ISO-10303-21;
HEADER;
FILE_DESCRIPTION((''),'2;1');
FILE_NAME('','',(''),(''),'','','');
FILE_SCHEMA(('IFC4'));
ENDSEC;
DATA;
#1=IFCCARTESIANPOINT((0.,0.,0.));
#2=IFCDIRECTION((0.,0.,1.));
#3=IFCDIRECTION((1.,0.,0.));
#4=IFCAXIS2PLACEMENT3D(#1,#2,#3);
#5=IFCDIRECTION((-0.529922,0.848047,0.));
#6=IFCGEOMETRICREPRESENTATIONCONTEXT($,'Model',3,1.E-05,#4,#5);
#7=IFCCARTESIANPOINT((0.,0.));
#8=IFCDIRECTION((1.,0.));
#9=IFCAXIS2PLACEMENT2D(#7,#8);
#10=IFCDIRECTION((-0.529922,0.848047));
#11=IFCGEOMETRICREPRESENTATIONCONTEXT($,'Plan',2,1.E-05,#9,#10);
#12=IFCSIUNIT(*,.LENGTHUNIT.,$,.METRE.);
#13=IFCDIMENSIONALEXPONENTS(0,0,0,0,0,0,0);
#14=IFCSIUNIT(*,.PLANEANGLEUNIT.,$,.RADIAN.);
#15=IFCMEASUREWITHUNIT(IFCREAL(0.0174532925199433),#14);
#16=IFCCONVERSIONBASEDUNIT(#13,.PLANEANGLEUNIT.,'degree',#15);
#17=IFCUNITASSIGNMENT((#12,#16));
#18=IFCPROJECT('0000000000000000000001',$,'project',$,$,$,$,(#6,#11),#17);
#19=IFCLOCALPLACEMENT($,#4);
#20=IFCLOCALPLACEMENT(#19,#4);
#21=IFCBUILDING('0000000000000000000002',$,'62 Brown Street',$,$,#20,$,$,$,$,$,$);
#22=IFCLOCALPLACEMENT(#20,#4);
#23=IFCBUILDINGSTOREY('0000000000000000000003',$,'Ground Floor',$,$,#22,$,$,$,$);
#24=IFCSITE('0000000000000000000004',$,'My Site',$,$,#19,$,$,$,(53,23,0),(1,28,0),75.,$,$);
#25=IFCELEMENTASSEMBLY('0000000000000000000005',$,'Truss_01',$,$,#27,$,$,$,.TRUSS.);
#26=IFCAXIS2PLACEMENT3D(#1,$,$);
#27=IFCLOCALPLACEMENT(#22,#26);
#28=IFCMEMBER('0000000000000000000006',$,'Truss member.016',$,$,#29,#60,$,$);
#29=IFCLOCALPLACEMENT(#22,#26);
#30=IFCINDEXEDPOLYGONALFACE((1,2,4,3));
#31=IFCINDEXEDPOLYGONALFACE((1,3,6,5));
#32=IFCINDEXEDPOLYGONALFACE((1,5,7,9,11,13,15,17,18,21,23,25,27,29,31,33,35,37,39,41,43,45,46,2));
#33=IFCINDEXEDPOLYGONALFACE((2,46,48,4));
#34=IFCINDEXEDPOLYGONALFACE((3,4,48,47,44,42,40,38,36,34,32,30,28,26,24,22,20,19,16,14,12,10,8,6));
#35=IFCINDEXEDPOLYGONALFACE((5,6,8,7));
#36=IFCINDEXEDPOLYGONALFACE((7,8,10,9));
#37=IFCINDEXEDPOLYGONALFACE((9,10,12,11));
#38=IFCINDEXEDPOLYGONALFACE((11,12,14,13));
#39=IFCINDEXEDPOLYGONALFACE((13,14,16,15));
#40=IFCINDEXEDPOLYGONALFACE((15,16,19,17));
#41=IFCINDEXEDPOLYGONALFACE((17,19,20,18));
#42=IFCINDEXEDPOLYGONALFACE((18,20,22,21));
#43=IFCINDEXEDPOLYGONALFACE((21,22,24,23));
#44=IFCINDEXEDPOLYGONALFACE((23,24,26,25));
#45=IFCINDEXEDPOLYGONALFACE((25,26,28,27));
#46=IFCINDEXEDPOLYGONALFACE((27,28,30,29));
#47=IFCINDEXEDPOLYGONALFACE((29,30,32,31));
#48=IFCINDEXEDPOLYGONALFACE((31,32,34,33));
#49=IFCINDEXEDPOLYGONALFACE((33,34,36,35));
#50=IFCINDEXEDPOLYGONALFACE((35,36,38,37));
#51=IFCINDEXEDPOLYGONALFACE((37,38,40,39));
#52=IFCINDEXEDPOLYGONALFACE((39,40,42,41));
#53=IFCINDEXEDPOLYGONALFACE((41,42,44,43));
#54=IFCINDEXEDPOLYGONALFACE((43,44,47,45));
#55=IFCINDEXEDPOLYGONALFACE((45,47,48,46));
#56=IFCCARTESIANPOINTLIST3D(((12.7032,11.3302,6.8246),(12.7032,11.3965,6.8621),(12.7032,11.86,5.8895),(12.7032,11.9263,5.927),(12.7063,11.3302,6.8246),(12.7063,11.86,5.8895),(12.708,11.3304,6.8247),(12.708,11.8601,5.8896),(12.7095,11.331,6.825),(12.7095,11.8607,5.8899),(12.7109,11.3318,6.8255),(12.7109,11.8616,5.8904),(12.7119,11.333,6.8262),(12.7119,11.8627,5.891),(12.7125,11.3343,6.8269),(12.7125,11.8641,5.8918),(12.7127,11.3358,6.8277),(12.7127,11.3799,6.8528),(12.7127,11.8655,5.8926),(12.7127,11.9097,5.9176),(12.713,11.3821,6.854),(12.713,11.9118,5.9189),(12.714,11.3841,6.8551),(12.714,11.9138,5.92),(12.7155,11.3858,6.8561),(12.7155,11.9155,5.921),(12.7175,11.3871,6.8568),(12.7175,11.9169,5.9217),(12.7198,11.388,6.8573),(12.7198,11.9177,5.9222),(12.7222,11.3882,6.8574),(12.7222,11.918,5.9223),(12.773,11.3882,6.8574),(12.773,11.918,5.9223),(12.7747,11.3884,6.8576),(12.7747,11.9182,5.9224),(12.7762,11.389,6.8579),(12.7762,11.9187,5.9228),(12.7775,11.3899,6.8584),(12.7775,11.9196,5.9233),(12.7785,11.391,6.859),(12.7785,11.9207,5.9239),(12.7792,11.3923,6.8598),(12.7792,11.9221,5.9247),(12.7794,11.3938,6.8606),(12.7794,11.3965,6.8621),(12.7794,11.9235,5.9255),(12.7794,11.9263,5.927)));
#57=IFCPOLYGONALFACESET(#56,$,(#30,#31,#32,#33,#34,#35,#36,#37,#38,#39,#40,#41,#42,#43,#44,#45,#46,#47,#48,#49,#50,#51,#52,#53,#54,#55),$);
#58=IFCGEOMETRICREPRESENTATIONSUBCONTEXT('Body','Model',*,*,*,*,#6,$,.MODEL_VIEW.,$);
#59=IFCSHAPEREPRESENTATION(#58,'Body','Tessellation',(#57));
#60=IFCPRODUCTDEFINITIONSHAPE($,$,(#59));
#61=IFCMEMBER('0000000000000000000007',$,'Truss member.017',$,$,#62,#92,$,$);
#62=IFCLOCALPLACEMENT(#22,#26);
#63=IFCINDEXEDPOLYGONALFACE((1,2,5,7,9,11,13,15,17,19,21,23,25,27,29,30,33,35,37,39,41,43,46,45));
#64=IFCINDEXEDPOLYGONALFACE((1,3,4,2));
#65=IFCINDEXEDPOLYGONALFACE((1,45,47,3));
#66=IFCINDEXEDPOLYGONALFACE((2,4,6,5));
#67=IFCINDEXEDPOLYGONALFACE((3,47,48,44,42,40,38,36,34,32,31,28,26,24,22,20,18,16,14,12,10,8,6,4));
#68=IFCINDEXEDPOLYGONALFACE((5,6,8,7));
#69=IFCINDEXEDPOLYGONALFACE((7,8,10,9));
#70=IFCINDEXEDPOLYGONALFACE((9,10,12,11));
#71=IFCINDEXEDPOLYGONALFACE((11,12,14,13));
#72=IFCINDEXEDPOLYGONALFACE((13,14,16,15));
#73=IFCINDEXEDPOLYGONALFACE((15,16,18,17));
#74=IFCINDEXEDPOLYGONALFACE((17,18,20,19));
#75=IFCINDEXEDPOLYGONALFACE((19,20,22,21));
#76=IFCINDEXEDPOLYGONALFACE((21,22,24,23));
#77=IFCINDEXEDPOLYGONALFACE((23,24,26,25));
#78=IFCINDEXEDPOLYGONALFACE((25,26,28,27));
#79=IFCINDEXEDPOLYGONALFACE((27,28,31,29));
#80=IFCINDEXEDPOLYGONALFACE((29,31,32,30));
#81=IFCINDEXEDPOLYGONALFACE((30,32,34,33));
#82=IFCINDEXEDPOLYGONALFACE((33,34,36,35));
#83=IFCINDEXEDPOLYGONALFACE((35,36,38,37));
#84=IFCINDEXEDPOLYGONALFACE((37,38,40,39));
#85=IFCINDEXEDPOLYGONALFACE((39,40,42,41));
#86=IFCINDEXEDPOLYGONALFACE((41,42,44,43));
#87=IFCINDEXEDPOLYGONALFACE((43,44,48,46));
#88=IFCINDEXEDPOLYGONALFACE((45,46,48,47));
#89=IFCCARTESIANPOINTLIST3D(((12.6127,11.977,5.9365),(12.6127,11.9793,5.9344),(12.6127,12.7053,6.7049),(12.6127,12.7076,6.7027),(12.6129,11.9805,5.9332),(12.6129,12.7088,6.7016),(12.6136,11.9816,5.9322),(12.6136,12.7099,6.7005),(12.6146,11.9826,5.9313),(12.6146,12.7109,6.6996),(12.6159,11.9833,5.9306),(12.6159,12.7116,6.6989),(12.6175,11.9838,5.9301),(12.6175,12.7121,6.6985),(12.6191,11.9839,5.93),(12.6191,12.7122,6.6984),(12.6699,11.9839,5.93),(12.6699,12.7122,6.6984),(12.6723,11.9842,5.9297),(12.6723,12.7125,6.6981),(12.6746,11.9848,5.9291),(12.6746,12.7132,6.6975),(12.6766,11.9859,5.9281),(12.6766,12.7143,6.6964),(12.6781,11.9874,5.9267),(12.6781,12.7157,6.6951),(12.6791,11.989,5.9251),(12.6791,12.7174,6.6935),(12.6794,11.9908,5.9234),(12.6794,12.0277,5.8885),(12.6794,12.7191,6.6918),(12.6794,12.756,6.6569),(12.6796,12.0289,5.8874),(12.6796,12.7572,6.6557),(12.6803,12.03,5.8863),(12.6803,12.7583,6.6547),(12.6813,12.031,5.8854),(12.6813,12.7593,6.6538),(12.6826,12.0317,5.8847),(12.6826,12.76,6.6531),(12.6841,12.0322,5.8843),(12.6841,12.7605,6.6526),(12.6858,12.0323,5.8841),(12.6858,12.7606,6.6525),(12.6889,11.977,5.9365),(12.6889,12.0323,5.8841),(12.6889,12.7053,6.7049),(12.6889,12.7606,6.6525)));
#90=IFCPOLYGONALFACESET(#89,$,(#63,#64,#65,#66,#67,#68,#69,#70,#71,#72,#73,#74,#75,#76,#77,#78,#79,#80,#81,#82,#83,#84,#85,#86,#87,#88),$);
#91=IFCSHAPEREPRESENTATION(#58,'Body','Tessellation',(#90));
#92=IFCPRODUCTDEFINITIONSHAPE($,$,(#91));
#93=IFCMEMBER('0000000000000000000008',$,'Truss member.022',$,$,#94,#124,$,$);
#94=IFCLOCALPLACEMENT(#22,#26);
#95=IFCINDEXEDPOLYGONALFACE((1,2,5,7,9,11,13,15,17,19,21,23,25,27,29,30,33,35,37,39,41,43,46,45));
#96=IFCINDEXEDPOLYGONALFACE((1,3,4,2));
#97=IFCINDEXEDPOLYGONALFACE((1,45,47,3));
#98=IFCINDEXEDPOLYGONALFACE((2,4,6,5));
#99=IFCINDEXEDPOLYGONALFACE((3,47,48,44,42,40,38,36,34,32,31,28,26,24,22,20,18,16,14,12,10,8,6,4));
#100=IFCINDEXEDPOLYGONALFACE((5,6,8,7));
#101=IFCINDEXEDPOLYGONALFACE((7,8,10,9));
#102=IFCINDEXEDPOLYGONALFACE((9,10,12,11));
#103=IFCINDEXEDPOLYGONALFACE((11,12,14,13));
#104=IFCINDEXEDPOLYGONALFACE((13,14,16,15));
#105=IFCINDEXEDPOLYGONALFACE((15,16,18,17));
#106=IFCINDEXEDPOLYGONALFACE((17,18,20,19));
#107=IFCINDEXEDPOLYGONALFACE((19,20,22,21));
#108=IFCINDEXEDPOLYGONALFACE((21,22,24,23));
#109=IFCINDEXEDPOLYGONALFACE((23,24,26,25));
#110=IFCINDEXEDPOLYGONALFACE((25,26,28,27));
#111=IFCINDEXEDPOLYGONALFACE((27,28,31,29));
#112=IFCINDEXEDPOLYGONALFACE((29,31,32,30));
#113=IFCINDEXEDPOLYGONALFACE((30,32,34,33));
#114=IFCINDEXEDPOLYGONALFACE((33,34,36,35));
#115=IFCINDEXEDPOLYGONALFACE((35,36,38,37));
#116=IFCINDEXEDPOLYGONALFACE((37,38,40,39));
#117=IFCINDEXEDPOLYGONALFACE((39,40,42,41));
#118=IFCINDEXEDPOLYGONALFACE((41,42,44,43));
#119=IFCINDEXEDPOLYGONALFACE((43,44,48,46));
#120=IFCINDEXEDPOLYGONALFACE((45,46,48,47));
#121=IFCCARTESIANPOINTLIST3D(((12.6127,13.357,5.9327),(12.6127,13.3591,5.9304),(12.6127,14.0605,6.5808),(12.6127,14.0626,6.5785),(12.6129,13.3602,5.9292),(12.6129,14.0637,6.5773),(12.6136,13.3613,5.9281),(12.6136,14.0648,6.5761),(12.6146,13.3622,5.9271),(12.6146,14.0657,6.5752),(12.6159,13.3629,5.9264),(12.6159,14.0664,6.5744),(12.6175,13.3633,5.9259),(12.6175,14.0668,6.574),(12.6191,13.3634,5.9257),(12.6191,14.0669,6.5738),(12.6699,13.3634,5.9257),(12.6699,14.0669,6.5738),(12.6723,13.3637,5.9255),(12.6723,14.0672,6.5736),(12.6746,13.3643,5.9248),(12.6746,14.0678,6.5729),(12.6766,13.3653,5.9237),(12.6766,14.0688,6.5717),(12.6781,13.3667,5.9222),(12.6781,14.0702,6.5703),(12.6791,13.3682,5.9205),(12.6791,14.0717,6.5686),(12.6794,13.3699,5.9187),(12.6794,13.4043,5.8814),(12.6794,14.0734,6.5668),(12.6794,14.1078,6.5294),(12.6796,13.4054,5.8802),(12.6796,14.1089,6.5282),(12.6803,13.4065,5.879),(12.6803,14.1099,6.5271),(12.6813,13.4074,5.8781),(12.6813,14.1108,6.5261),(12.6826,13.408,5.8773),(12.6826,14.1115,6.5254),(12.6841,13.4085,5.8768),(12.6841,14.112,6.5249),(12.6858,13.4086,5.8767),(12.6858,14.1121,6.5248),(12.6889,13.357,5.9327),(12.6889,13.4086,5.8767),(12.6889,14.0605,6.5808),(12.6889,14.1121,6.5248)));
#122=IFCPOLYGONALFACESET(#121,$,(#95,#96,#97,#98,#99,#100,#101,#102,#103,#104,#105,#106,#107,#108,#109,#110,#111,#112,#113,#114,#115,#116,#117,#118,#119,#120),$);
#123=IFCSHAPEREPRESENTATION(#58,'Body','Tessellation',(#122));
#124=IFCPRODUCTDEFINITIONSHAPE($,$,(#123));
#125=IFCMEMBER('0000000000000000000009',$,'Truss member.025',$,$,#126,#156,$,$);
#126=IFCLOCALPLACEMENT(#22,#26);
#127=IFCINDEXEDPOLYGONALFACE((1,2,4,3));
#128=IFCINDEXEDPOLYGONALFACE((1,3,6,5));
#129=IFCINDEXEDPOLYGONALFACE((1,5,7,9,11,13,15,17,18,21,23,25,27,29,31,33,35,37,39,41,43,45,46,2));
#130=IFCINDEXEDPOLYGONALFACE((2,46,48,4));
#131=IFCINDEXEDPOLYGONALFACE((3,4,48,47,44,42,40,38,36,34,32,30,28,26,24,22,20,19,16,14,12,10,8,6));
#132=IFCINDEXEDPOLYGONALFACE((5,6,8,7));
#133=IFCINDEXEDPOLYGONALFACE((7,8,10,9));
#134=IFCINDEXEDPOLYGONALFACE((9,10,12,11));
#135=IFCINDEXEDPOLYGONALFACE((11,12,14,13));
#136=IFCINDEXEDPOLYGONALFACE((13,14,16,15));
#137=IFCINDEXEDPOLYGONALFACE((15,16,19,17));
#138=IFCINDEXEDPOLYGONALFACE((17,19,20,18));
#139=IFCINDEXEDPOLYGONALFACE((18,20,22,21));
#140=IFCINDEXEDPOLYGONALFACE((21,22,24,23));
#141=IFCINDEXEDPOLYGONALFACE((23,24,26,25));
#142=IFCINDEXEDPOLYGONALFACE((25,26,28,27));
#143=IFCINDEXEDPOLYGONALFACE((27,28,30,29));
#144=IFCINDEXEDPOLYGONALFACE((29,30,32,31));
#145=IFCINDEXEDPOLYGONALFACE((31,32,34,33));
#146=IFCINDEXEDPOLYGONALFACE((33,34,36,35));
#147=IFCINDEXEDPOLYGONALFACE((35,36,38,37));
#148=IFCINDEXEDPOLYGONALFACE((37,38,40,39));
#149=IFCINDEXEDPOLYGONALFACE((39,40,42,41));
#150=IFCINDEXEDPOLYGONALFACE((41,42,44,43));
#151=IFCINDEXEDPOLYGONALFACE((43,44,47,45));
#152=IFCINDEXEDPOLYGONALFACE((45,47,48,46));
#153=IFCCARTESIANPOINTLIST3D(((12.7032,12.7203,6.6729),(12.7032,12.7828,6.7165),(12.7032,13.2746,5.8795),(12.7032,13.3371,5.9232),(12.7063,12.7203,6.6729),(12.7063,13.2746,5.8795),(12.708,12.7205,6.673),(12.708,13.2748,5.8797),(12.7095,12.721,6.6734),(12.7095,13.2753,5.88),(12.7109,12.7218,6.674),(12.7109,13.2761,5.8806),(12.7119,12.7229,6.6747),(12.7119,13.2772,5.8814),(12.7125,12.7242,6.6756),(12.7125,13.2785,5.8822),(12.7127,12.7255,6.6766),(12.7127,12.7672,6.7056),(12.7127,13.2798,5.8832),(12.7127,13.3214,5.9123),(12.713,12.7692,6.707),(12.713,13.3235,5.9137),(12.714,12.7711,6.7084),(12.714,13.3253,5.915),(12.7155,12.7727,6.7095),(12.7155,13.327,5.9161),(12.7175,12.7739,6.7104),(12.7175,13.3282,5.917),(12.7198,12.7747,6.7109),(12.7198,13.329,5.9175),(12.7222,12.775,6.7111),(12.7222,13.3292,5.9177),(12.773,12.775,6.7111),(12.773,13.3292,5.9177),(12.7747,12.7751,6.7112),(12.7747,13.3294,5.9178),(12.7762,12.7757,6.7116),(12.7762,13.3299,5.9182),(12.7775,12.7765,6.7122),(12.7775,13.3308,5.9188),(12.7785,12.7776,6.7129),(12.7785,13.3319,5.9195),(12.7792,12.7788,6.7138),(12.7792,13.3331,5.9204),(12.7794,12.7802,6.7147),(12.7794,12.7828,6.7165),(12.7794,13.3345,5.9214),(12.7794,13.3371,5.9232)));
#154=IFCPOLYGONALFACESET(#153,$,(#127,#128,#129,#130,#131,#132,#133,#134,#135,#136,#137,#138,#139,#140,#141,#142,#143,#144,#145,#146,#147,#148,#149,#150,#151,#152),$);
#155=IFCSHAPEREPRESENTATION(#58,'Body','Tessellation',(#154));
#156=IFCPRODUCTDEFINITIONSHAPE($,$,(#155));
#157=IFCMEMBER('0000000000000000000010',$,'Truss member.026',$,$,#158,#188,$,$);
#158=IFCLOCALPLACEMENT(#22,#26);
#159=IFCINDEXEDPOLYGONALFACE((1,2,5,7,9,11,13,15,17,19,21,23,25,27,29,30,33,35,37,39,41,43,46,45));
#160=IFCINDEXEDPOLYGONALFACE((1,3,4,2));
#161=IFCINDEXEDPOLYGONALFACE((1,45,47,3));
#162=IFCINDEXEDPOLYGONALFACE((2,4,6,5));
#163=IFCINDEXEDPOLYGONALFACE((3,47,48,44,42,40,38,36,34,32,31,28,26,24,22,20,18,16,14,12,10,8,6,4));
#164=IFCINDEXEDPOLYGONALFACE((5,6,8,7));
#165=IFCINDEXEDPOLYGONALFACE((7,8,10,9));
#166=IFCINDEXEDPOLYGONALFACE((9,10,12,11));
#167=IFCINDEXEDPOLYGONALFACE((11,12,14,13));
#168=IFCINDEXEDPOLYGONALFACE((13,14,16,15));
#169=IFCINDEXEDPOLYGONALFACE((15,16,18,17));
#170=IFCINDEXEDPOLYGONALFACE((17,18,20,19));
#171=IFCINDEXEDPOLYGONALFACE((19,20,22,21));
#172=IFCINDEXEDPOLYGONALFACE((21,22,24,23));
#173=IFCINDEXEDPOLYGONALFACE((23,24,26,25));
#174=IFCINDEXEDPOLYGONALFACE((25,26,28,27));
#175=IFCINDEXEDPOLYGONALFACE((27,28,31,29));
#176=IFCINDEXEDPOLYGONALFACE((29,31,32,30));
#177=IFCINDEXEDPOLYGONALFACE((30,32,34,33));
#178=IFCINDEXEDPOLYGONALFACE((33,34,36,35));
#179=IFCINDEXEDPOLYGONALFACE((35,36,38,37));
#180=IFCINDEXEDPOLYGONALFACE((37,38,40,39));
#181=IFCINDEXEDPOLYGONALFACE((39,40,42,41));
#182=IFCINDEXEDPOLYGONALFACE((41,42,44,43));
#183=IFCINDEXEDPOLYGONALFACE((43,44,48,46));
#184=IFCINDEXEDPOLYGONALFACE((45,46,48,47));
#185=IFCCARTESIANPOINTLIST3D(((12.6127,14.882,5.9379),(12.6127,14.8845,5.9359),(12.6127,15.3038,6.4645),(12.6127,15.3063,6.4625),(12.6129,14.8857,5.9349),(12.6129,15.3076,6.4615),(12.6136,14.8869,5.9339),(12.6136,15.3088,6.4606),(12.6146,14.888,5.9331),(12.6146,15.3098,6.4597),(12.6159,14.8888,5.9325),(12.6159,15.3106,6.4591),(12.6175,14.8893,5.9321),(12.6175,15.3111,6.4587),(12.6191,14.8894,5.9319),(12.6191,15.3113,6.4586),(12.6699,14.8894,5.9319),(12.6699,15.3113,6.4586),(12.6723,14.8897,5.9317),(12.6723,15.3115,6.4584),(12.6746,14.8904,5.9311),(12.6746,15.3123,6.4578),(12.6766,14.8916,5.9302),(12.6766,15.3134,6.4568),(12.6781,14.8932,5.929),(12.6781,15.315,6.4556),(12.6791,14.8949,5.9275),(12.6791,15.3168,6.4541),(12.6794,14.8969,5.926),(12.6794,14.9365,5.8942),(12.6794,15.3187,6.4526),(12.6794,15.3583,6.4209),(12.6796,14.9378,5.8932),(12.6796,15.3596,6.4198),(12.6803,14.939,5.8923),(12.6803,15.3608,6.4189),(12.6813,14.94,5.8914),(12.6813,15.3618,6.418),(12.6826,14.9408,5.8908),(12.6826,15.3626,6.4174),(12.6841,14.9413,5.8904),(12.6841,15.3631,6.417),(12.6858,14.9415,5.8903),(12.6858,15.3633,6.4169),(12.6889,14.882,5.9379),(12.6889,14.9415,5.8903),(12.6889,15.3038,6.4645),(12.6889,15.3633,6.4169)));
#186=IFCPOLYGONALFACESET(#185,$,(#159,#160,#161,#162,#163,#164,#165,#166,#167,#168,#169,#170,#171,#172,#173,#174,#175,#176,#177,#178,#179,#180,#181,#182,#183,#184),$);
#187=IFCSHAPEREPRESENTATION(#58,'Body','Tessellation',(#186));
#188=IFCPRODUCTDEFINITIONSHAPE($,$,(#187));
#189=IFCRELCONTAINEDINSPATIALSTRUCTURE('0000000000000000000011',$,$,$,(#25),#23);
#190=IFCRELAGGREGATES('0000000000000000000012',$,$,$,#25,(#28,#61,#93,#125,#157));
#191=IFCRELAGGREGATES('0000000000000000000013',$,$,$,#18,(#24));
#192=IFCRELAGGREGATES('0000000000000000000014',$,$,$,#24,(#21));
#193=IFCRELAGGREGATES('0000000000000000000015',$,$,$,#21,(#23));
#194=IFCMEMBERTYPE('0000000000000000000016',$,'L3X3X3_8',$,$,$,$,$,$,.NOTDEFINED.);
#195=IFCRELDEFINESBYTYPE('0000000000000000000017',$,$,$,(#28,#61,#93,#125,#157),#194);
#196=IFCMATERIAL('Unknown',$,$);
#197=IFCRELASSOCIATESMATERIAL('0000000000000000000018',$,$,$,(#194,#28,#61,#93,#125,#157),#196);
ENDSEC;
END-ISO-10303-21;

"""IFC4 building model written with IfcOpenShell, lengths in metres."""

from ifc_helpers import new_model, entity, si_unit, converted_unit, direction, frame, origin_with_axes, origin_2d_with_axis, place, context, subcontext, project, spatial, l_section, extrude, material, material_profile, profile_set, profile_usage, type_object, element, aggregate, save


model = new_model("IFC4")

# Units and contexts
model_context = context("Model", 3, precision=1e-05, world=origin_with_axes(), true_north=direction((-0.529922, 0.848047, 0.0)))
plan_context = context("Plan", 2, precision=1e-05, world=origin_2d_with_axis(), true_north=direction((-0.529922, 0.848047)))
body_context = subcontext(model_context, "Body", "Model", "MODEL_VIEW")
ifc_project = project(units=[si_unit("LENGTHUNIT", "METRE"), converted_unit("PLANEANGLEUNIT", "degree", entity("IfcReal", 0.0174532925199433), si_unit("PLANEANGLEUNIT", "RADIAN"), dimensions=[0, 0, 0, 0, 0, 0, 0])], contexts=[model_context, plan_context])

# Site, building, storey
site_placement = place(None, origin_with_axes())
site = spatial("IfcSite", under=ifc_project, at=site_placement, Name="My Site", RefLatitude=(53, 23, 0), RefLongitude=(1, 28, 0), RefElevation=75.0)
building_placement = place(site_placement, origin_with_axes())
building = spatial("IfcBuilding", under=site, at=building_placement, Name="62 Brown Street")
storey_placement = place(building_placement, origin_with_axes())
storey = spatial("IfcBuildingStorey", under=building, at=storey_placement, Name="Ground Floor")

# Element assembly, members
ifc_material_1 = material(Name="Unknown")
ifc_material_profile_1 = material_profile(ifc_material_1, l_section(Depth=0.0762, Width=0.0762, Thickness=0.0095, FilletRadius=0.0095, EdgeRadius=0.0064))
ifc_profile_set_1 = profile_set([ifc_material_profile_1])
member_type_1 = type_object("IfcMemberType", Name="L3X3X3_8", PredefinedType="NOTDEFINED", material=ifc_profile_set_1)
assembly_1_placement = place(storey_placement, frame((12.7032, 10.4288, 6.9738), z_axis=(0.0, 0.0, 1.0), x_axis=(1.0, 0.0, 0.0)))
assembly_1 = element("IfcElementAssembly", 1, at=assembly_1_placement, inside=storey, Name="Truss_01", PredefinedType="TRUSS")
ifc_profile_usage_1 = profile_usage(ifc_profile_set_1, cardinal=5)
member_1_placement = place(assembly_1_placement, frame((0.0381, 0.9346, -0.1304), z_axis=(0.0, 0.492899, -0.870086), x_axis=(1.0, 0.0, 0.0)))
member_1 = element("IfcMember", 2, at=member_1_placement, type_object=member_type_1, material=ifc_profile_usage_1, Name="Truss member.016", context=body_context, shape_type="SweptSolid", body=[
    extrude(l_section(Depth=0.0762, Width=0.0762, Thickness=0.0095, FilletRadius=0.0095, EdgeRadius=0.0064), origin_with_axes(), (0.0, 0.0, 1.0), 1.0747),
])
ifc_profile_usage_2 = profile_usage(ifc_profile_set_1, cardinal=5)
member_2_placement = place(assembly_1_placement, frame((-0.0524, 2.3042, -0.2951), z_axis=(0.000001, -0.687927, -0.72578), x_axis=(-1.0, 0.0, 0.0)))
member_2 = element("IfcMember", 3, at=member_2_placement, type_object=member_type_1, material=ifc_profile_usage_2, Name="Truss member.017", context=body_context, shape_type="SweptSolid", body=[
    extrude(l_section(Depth=0.0762, Width=0.0762, Thickness=0.0095, FilletRadius=0.0095, EdgeRadius=0.0064), origin_with_axes(), (0.0, 0.0, 1.0), 1.0587),
])
ifc_profile_usage_3 = profile_usage(ifc_profile_set_1, cardinal=5)
member_3_placement = place(assembly_1_placement, frame((-0.0524, 3.6575, -0.421), z_axis=(0.000001, -0.735484, -0.677542), x_axis=(-1.0, -0.000001, 0.0)))
member_3 = element("IfcMember", 4, at=member_3_placement, type_object=member_type_1, material=ifc_profile_usage_3, Name="Truss member.022", context=body_context, shape_type="SweptSolid", body=[
    extrude(l_section(Depth=0.0762, Width=0.0762, Thickness=0.0095, FilletRadius=0.0095, EdgeRadius=0.0064), origin_with_axes(), (0.0, 0.0, 1.0), 0.9565),
])
ifc_profile_usage_4 = profile_usage(ifc_profile_set_1, cardinal=5)
member_4_placement = place(assembly_1_placement, frame((0.0381, 2.3228, -0.279), z_axis=(-0.000001, 0.572709, -0.819759), x_axis=(1.0, 0.0, 0.0)))
member_4 = element("IfcMember", 5, at=member_4_placement, type_object=member_type_1, material=ifc_profile_usage_4, Name="Truss member.025", context=body_context, shape_type="SweptSolid", body=[
    extrude(l_section(Depth=0.0762, Width=0.0762, Thickness=0.0095, FilletRadius=0.0095, EdgeRadius=0.0064), origin_with_axes(), (0.0, 0.0, 1.0), 0.9678),
])
ifc_profile_usage_5 = profile_usage(ifc_profile_set_1, cardinal=5)
member_5_placement = place(assembly_1_placement, frame((-0.0524, 4.9048, -0.5331), z_axis=(0.000001, -0.625169, -0.780489), x_axis=(-1.0, -0.000001, 0.0)))
member_5 = element("IfcMember", 6, at=member_5_placement, type_object=member_type_1, material=ifc_profile_usage_5, Name="Truss member.026", context=body_context, shape_type="SweptSolid", body=[
    extrude(l_section(Depth=0.0762, Width=0.0762, Thickness=0.0095, FilletRadius=0.0095, EdgeRadius=0.0064), origin_with_axes(), (0.0, 0.0, 1.0), 0.6747),
])

aggregate(assembly_1, [member_1, member_2, member_3, member_4, member_5])

save(model, "model.ifc")
